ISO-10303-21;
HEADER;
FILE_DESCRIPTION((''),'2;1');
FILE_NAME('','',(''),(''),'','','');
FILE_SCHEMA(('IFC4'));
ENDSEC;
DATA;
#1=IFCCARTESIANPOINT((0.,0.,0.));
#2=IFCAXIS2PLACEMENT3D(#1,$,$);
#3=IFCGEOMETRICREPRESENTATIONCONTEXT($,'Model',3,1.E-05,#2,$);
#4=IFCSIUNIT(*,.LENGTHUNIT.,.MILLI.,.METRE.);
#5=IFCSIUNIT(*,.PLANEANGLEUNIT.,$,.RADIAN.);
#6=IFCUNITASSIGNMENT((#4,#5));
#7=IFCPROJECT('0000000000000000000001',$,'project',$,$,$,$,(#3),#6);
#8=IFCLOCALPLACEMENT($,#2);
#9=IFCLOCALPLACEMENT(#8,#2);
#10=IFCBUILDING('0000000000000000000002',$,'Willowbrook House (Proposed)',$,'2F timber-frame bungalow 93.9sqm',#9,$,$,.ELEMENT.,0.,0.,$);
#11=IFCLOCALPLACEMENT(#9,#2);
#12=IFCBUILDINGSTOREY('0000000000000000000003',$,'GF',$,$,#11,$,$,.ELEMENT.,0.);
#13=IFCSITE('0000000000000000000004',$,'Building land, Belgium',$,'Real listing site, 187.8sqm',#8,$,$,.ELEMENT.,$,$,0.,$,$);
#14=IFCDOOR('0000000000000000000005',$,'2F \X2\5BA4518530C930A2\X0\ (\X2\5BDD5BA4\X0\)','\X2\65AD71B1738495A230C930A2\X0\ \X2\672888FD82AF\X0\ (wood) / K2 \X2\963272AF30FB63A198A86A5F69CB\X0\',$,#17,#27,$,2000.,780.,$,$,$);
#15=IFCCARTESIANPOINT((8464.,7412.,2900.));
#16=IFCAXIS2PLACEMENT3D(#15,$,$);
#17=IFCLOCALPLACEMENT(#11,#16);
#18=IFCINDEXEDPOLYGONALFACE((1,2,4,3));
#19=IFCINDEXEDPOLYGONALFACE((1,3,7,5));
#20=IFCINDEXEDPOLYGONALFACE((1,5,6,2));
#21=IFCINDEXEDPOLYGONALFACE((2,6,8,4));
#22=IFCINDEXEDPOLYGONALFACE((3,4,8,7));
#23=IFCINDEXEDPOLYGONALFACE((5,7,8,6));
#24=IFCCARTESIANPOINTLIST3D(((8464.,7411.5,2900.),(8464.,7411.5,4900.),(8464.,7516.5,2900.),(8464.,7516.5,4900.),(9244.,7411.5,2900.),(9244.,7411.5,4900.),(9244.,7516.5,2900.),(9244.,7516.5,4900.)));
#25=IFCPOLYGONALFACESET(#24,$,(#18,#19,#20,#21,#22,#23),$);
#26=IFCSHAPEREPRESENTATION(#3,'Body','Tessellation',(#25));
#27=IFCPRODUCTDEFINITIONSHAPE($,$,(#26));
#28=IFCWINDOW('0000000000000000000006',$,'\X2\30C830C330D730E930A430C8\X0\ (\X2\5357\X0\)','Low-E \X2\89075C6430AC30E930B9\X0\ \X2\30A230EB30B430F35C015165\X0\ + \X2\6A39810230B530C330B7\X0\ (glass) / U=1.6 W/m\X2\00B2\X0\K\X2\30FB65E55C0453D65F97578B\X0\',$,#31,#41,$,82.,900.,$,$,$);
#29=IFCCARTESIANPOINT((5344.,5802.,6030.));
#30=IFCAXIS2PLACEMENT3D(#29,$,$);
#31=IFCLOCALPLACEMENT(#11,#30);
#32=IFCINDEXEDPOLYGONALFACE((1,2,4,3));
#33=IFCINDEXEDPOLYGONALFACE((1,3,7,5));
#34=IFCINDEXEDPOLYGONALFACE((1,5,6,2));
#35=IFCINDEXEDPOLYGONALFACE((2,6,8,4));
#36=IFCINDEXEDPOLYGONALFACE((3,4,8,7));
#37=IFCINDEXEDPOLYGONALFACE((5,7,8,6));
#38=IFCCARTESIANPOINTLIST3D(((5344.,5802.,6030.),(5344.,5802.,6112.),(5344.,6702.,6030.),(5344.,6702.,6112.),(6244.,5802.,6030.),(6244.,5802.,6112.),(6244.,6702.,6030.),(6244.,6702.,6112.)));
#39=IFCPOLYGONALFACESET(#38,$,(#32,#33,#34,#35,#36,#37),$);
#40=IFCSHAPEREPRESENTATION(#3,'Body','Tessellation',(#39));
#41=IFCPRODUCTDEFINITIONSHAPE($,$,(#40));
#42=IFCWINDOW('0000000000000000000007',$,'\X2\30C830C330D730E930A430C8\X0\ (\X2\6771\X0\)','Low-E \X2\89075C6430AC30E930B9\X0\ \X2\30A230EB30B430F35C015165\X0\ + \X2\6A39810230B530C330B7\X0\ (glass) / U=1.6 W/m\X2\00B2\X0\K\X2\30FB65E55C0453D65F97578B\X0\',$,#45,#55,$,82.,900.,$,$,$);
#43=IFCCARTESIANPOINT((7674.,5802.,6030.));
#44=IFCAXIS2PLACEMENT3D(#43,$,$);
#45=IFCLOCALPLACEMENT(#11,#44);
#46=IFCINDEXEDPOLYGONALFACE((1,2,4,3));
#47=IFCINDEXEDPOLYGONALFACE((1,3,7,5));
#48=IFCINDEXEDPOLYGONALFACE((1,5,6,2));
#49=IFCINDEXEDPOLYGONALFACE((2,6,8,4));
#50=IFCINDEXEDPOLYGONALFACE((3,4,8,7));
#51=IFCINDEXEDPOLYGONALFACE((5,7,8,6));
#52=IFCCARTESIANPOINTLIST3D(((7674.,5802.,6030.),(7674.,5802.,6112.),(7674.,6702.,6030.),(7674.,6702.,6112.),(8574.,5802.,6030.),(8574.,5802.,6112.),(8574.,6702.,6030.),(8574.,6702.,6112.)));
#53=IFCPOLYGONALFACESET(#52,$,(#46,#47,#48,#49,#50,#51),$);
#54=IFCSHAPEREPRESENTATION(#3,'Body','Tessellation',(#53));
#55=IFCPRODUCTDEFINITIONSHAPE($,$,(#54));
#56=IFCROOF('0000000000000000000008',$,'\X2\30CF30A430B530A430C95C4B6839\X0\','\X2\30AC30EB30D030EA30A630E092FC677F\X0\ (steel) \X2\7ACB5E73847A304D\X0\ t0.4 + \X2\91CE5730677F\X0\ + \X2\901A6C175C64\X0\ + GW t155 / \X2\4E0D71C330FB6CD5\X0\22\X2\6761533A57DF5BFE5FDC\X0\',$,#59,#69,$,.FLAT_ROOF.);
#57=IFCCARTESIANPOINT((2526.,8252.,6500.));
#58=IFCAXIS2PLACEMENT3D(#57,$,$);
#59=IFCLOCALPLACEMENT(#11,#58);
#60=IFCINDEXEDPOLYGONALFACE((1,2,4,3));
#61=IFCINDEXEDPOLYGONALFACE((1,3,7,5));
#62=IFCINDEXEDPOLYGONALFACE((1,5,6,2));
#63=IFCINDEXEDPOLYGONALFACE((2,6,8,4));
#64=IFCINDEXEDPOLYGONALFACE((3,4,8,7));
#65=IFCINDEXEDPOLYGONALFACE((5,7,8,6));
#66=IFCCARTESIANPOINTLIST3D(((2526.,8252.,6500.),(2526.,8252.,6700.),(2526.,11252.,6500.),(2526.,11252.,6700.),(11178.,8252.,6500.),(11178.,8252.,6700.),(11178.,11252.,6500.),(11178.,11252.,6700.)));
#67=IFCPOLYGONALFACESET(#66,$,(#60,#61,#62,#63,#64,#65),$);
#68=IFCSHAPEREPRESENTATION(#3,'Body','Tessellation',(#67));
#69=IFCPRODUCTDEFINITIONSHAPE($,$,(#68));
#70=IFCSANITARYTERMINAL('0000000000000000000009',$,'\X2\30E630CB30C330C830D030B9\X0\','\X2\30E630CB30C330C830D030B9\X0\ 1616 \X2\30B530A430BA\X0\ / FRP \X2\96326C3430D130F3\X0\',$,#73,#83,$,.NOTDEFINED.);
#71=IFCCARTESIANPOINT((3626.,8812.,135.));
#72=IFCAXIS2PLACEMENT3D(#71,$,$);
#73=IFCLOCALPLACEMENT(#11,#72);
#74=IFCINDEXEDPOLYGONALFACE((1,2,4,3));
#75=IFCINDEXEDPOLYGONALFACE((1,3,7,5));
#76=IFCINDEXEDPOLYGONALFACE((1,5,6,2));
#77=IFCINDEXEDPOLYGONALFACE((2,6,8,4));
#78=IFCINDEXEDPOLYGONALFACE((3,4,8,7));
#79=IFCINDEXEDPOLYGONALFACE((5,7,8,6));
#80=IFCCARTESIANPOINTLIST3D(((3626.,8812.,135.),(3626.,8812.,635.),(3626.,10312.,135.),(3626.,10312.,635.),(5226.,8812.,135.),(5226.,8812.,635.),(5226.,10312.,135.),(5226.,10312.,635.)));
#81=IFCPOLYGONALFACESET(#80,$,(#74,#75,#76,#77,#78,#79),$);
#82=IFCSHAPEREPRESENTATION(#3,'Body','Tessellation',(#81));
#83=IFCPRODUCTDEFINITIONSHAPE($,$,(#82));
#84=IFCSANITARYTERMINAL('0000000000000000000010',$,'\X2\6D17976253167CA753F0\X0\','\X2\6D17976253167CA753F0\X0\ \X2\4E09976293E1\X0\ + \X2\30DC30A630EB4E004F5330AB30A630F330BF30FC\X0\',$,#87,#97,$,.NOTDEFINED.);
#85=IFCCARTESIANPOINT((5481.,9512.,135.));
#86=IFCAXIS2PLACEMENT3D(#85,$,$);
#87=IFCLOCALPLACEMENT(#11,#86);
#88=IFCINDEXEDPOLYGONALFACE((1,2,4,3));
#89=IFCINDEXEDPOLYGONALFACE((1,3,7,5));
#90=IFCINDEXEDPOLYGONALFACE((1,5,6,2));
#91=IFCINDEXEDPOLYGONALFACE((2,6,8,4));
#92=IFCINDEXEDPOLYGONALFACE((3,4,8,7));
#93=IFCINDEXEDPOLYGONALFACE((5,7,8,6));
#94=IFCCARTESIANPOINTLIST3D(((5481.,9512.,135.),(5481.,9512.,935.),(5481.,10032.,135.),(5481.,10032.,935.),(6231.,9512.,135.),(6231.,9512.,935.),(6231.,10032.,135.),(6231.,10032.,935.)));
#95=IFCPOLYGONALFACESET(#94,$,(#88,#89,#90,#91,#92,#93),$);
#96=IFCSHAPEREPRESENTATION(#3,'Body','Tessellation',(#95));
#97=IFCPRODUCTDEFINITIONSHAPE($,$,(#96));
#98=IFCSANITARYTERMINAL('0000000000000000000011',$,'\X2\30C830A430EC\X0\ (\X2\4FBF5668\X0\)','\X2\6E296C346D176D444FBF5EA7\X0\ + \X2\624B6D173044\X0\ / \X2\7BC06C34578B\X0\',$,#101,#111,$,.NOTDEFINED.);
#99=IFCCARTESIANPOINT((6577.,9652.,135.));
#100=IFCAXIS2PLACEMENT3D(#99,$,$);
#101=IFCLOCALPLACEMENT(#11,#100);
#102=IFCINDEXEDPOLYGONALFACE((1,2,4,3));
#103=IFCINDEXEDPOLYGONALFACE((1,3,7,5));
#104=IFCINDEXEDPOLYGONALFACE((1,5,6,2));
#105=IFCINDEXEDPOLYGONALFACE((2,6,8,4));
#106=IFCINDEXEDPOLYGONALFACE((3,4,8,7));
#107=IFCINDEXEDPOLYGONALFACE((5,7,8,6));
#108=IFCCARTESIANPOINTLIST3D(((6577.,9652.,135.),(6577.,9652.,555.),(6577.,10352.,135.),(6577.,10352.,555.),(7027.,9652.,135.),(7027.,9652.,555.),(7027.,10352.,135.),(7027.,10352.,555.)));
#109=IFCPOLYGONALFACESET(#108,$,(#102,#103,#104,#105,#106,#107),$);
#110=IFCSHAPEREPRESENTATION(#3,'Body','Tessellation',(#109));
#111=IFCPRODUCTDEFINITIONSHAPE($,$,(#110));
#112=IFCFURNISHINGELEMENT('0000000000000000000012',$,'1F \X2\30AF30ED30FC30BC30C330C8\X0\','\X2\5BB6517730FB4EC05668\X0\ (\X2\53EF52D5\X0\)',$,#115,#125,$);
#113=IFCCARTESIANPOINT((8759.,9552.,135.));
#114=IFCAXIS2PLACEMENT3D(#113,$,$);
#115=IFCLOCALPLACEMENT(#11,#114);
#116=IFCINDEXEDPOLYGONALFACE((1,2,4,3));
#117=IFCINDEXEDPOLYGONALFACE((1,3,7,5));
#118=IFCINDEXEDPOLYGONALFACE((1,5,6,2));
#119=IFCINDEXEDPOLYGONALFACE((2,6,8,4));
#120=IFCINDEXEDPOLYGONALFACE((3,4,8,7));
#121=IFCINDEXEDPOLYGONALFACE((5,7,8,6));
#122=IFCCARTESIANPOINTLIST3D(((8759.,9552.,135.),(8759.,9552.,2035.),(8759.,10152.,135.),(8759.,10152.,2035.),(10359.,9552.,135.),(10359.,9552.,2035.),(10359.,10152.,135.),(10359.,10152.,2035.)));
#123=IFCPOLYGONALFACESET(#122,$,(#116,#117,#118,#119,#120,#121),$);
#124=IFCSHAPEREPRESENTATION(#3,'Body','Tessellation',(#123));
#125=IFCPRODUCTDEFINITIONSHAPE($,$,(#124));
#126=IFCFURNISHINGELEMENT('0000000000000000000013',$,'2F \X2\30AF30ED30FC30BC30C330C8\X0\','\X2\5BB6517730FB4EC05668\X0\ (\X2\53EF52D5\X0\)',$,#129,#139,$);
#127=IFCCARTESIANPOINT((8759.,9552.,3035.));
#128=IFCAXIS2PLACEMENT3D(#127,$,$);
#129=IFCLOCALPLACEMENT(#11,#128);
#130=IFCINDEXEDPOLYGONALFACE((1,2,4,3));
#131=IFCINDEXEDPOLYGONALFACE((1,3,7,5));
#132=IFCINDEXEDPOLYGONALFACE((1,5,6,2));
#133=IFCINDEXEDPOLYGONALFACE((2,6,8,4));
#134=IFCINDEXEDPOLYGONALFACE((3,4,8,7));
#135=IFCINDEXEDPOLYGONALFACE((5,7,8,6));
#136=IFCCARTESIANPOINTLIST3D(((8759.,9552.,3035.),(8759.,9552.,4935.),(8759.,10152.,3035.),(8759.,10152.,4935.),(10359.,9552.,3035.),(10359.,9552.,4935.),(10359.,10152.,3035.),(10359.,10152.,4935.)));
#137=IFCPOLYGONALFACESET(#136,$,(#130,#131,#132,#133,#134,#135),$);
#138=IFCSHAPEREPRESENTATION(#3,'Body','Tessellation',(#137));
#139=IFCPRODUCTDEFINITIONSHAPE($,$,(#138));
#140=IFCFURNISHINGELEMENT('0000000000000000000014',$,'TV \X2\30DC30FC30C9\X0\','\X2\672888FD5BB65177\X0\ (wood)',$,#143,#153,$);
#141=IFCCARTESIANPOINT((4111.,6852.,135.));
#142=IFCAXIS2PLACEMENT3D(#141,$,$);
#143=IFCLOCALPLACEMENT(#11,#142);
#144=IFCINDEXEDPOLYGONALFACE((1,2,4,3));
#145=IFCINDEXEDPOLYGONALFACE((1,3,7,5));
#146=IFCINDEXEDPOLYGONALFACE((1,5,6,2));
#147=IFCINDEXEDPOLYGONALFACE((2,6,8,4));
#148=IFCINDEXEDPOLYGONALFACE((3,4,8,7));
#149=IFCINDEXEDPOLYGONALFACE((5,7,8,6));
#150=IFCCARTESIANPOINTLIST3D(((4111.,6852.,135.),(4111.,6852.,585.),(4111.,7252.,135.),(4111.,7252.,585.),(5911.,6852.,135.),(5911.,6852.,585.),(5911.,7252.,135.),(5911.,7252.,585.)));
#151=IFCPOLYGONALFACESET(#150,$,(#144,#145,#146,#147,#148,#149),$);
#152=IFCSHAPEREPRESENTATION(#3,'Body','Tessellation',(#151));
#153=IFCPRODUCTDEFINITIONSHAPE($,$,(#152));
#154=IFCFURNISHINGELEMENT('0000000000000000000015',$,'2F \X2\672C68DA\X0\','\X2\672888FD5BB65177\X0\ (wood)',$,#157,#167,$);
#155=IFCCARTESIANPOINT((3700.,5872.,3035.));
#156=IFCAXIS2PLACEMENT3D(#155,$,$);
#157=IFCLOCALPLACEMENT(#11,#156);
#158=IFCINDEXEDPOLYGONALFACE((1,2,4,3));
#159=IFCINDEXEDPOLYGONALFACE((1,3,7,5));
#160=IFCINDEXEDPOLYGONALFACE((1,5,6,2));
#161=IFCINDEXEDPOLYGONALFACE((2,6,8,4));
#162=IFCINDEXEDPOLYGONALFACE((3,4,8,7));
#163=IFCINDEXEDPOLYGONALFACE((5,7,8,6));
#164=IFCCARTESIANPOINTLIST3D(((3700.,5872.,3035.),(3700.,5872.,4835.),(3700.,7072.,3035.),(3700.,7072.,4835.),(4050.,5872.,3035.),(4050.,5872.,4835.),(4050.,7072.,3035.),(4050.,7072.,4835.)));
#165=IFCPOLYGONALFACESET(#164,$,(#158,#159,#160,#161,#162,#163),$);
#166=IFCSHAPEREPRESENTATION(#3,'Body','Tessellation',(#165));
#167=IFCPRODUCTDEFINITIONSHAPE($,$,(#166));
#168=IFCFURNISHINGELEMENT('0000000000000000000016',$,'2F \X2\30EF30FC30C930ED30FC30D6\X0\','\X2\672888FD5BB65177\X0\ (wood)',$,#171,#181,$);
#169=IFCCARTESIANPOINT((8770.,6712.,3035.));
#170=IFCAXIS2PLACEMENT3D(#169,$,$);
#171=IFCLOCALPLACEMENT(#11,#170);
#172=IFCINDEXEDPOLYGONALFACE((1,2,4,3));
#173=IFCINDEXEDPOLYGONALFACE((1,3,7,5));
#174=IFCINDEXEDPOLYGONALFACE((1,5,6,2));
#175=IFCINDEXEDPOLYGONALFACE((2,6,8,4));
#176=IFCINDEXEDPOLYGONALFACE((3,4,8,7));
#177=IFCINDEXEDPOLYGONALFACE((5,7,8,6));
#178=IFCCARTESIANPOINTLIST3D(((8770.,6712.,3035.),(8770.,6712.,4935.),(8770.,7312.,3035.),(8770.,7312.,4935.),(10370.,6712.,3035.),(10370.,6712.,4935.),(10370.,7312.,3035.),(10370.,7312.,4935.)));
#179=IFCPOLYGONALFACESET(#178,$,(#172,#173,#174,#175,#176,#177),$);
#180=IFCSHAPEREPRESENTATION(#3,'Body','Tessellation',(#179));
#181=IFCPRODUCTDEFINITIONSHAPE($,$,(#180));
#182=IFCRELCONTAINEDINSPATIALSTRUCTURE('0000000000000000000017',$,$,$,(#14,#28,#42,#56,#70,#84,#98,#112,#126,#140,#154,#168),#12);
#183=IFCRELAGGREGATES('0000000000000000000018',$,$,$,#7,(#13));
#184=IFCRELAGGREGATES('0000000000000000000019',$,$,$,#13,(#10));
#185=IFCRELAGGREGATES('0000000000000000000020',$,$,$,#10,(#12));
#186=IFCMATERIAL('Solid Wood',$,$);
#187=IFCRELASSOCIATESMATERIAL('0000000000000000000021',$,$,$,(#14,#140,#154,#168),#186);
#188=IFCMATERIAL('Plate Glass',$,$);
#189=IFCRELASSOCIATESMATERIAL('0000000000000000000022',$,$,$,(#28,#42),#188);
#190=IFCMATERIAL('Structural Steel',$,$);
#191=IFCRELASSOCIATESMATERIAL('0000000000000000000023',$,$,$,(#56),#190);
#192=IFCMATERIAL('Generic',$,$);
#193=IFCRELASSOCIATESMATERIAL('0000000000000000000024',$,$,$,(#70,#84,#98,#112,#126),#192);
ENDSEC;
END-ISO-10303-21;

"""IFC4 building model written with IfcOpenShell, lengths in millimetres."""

from ifc_helpers import new_model, si_unit, frame, frame_2d, origin, place, context, project, spatial, rectangle, extrude, material, element, save


model = new_model("IFC4")

# Units and contexts
model_context = context("Model", 3, precision=1e-05, world=origin())
ifc_project = project(units=[si_unit("LENGTHUNIT", "METRE", prefix="MILLI"), si_unit("PLANEANGLEUNIT", "RADIAN")], contexts=[model_context])

# Site, building, storey
site_placement = place(None, origin())
site = spatial("IfcSite", under=ifc_project, at=site_placement, Name="Building land, Belgium", ObjectType="Real listing site, 187.8sqm", CompositionType="ELEMENT", RefElevation=0.0)
building_placement = place(site_placement, origin())
building = spatial("IfcBuilding", under=site, at=building_placement, Name="Willowbrook House (Proposed)", ObjectType="2F timber-frame bungalow 93.9sqm", CompositionType="ELEMENT", ElevationOfRefHeight=0.0, ElevationOfTerrain=0.0)
storey_placement = place(building_placement, origin())
storey = spatial("IfcBuildingStorey", under=building, at=storey_placement, Name="GF", CompositionType="ELEMENT", Elevation=0.0)

# Shared definitions
ifc_material_1 = material(Name="Solid Wood")
ifc_material_2 = material(Name="Plate Glass")

# Door
door_1_placement = place(storey_placement, frame((8464.0, 7412.0, 2900.0)))
element("IfcDoor", 1, at=door_1_placement, inside=storey, material=ifc_material_1, Name="2F 室内ドア (寝室)", Description="断熱玄関ドア 木製芯 (wood) / K2 防犯・採風機構", OverallHeight=2000.0, OverallWidth=780.0, context=model_context, shape_type="SweptSolid", body=[
    extrude(rectangle(XDim=780.0, YDim=105.0, at=frame_2d((390.0, 52.0))), frame((8464.0, 7412.0, 2900.0)), (0.0, 0.0, 1.0), 2000.0),
])

# Windows
window_1_placement = place(storey_placement, frame((5344.0, 5802.0, 6030.0)))
element("IfcWindow", 2, at=window_1_placement, inside=storey, material=ifc_material_2, Name="トップライト (南)", Description="Low-E 複層ガラス アルゴン封入 + 樹脂サッシ (glass) / U=1.6 W/m²K・日射取得型", OverallHeight=82.0, OverallWidth=900.0, context=model_context, shape_type="SweptSolid", body=[
    extrude(rectangle(XDim=900.0, YDim=900.0, at=frame_2d((450.0, 450.0))), frame((5344.0, 5802.0, 6030.0)), (0.0, 0.0, 1.0), 82.0),
])
window_2_placement = place(storey_placement, frame((7674.0, 5802.0, 6030.0)))
element("IfcWindow", 3, at=window_2_placement, inside=storey, material=ifc_material_2, Name="トップライト (東)", Description="Low-E 複層ガラス アルゴン封入 + 樹脂サッシ (glass) / U=1.6 W/m²K・日射取得型", OverallHeight=82.0, OverallWidth=900.0, context=model_context, shape_type="SweptSolid", body=[
    extrude(rectangle(XDim=900.0, YDim=900.0, at=frame_2d((450.0, 450.0))), frame((7674.0, 5802.0, 6030.0)), (0.0, 0.0, 1.0), 82.0),
])

# Roof
ifc_material_3 = material(Name="Structural Steel")
roof_placement = place(storey_placement, frame((2526.0, 8252.0, 6500.0)))
element("IfcRoof", 4, at=roof_placement, inside=storey, material=ifc_material_3, Name="ハイサイド屋根", Description="ガルバリウム鋼板 (steel) 立平葺き t0.4 + 野地板 + 通気層 + GW t155 / 不燃・法22条区域対応", PredefinedType="FLAT_ROOF", context=model_context, shape_type="SweptSolid", body=[
    extrude(rectangle(XDim=8652.0, YDim=3000.0, at=frame_2d((4326.0, 1500.0))), frame((2526.0, 8252.0, 6500.0)), (0.0, 0.0, 1.0), 200.0),
])

# Sanitary terminals
ifc_material_4 = material(Name="Generic")
sanitary_terminal_1_placement = place(storey_placement, frame((3626.0, 8812.0, 135.0)))
element("IfcSanitaryTerminal", 5, at=sanitary_terminal_1_placement, inside=storey, material=ifc_material_4, Name="ユニットバス", Description="ユニットバス 1616 サイズ / FRP 防水パン", PredefinedType="NOTDEFINED", context=model_context, shape_type="SweptSolid", body=[
    extrude(rectangle(XDim=1600.0, YDim=1500.0, at=frame_2d((800.0, 750.0))), frame((3626.0, 8812.0, 135.0)), (0.0, 0.0, 1.0), 500.0),
])
sanitary_terminal_2_placement = place(storey_placement, frame((5481.0, 9512.0, 135.0)))
element("IfcSanitaryTerminal", 6, at=sanitary_terminal_2_placement, inside=storey, material=ifc_material_4, Name="洗面化粧台", Description="洗面化粧台 三面鏡 + ボウル一体カウンター", PredefinedType="NOTDEFINED", context=model_context, shape_type="SweptSolid", body=[
    extrude(rectangle(XDim=750.0, YDim=520.0, at=frame_2d((375.0, 260.0))), frame((5481.0, 9512.0, 135.0)), (0.0, 0.0, 1.0), 800.0),
])
sanitary_terminal_3_placement = place(storey_placement, frame((6577.0, 9652.0, 135.0)))
element("IfcSanitaryTerminal", 7, at=sanitary_terminal_3_placement, inside=storey, material=ifc_material_4, Name="トイレ (便器)", Description="温水洗浄便座 + 手洗い / 節水型", PredefinedType="NOTDEFINED", context=model_context, shape_type="SweptSolid", body=[
    extrude(rectangle(XDim=450.0, YDim=700.0, at=frame_2d((225.0, 350.0))), frame((6577.0, 9652.0, 135.0)), (0.0, 0.0, 1.0), 420.0),
])

# Furnishing elements
furnishing_1_placement = place(storey_placement, frame((8759.0, 9552.0, 135.0)))
element("IfcFurnishingElement", 8, at=furnishing_1_placement, inside=storey, material=ifc_material_4, Name="1F クローゼット", Description="家具・什器 (可動)", context=model_context, shape_type="SweptSolid", body=[
    extrude(rectangle(XDim=1600.0, YDim=600.0, at=frame_2d((800.0, 300.0))), frame((8759.0, 9552.0, 135.0)), (0.0, 0.0, 1.0), 1900.0),
])
furnishing_2_placement = place(storey_placement, frame((8759.0, 9552.0, 3035.0)))
element("IfcFurnishingElement", 9, at=furnishing_2_placement, inside=storey, material=ifc_material_4, Name="2F クローゼット", Description="家具・什器 (可動)", context=model_context, shape_type="SweptSolid", body=[
    extrude(rectangle(XDim=1600.0, YDim=600.0, at=frame_2d((800.0, 300.0))), frame((8759.0, 9552.0, 3035.0)), (0.0, 0.0, 1.0), 1900.0),
])
furnishing_3_placement = place(storey_placement, frame((4111.0, 6852.0, 135.0)))
element("IfcFurnishingElement", 10, at=furnishing_3_placement, inside=storey, material=ifc_material_1, Name="TV ボード", Description="木製家具 (wood)", context=model_context, shape_type="SweptSolid", body=[
    extrude(rectangle(XDim=1800.0, YDim=400.0, at=frame_2d((900.0, 200.0))), frame((4111.0, 6852.0, 135.0)), (0.0, 0.0, 1.0), 450.0),
])
furnishing_4_placement = place(storey_placement, frame((3700.0, 5872.0, 3035.0)))
element("IfcFurnishingElement", 11, at=furnishing_4_placement, inside=storey, material=ifc_material_1, Name="2F 本棚", Description="木製家具 (wood)", context=model_context, shape_type="SweptSolid", body=[
    extrude(rectangle(XDim=350.0, YDim=1200.0, at=frame_2d((175.0, 600.0))), frame((3700.0, 5872.0, 3035.0)), (0.0, 0.0, 1.0), 1800.0),
])
furnishing_5_placement = place(storey_placement, frame((8770.0, 6712.0, 3035.0)))
element("IfcFurnishingElement", 12, at=furnishing_5_placement, inside=storey, material=ifc_material_1, Name="2F ワードローブ", Description="木製家具 (wood)", context=model_context, shape_type="SweptSolid", body=[
    extrude(rectangle(XDim=1600.0, YDim=600.0, at=frame_2d((800.0, 300.0))), frame((8770.0, 6712.0, 3035.0)), (0.0, 0.0, 1.0), 1900.0),
])

save(model, "model.ifc")
